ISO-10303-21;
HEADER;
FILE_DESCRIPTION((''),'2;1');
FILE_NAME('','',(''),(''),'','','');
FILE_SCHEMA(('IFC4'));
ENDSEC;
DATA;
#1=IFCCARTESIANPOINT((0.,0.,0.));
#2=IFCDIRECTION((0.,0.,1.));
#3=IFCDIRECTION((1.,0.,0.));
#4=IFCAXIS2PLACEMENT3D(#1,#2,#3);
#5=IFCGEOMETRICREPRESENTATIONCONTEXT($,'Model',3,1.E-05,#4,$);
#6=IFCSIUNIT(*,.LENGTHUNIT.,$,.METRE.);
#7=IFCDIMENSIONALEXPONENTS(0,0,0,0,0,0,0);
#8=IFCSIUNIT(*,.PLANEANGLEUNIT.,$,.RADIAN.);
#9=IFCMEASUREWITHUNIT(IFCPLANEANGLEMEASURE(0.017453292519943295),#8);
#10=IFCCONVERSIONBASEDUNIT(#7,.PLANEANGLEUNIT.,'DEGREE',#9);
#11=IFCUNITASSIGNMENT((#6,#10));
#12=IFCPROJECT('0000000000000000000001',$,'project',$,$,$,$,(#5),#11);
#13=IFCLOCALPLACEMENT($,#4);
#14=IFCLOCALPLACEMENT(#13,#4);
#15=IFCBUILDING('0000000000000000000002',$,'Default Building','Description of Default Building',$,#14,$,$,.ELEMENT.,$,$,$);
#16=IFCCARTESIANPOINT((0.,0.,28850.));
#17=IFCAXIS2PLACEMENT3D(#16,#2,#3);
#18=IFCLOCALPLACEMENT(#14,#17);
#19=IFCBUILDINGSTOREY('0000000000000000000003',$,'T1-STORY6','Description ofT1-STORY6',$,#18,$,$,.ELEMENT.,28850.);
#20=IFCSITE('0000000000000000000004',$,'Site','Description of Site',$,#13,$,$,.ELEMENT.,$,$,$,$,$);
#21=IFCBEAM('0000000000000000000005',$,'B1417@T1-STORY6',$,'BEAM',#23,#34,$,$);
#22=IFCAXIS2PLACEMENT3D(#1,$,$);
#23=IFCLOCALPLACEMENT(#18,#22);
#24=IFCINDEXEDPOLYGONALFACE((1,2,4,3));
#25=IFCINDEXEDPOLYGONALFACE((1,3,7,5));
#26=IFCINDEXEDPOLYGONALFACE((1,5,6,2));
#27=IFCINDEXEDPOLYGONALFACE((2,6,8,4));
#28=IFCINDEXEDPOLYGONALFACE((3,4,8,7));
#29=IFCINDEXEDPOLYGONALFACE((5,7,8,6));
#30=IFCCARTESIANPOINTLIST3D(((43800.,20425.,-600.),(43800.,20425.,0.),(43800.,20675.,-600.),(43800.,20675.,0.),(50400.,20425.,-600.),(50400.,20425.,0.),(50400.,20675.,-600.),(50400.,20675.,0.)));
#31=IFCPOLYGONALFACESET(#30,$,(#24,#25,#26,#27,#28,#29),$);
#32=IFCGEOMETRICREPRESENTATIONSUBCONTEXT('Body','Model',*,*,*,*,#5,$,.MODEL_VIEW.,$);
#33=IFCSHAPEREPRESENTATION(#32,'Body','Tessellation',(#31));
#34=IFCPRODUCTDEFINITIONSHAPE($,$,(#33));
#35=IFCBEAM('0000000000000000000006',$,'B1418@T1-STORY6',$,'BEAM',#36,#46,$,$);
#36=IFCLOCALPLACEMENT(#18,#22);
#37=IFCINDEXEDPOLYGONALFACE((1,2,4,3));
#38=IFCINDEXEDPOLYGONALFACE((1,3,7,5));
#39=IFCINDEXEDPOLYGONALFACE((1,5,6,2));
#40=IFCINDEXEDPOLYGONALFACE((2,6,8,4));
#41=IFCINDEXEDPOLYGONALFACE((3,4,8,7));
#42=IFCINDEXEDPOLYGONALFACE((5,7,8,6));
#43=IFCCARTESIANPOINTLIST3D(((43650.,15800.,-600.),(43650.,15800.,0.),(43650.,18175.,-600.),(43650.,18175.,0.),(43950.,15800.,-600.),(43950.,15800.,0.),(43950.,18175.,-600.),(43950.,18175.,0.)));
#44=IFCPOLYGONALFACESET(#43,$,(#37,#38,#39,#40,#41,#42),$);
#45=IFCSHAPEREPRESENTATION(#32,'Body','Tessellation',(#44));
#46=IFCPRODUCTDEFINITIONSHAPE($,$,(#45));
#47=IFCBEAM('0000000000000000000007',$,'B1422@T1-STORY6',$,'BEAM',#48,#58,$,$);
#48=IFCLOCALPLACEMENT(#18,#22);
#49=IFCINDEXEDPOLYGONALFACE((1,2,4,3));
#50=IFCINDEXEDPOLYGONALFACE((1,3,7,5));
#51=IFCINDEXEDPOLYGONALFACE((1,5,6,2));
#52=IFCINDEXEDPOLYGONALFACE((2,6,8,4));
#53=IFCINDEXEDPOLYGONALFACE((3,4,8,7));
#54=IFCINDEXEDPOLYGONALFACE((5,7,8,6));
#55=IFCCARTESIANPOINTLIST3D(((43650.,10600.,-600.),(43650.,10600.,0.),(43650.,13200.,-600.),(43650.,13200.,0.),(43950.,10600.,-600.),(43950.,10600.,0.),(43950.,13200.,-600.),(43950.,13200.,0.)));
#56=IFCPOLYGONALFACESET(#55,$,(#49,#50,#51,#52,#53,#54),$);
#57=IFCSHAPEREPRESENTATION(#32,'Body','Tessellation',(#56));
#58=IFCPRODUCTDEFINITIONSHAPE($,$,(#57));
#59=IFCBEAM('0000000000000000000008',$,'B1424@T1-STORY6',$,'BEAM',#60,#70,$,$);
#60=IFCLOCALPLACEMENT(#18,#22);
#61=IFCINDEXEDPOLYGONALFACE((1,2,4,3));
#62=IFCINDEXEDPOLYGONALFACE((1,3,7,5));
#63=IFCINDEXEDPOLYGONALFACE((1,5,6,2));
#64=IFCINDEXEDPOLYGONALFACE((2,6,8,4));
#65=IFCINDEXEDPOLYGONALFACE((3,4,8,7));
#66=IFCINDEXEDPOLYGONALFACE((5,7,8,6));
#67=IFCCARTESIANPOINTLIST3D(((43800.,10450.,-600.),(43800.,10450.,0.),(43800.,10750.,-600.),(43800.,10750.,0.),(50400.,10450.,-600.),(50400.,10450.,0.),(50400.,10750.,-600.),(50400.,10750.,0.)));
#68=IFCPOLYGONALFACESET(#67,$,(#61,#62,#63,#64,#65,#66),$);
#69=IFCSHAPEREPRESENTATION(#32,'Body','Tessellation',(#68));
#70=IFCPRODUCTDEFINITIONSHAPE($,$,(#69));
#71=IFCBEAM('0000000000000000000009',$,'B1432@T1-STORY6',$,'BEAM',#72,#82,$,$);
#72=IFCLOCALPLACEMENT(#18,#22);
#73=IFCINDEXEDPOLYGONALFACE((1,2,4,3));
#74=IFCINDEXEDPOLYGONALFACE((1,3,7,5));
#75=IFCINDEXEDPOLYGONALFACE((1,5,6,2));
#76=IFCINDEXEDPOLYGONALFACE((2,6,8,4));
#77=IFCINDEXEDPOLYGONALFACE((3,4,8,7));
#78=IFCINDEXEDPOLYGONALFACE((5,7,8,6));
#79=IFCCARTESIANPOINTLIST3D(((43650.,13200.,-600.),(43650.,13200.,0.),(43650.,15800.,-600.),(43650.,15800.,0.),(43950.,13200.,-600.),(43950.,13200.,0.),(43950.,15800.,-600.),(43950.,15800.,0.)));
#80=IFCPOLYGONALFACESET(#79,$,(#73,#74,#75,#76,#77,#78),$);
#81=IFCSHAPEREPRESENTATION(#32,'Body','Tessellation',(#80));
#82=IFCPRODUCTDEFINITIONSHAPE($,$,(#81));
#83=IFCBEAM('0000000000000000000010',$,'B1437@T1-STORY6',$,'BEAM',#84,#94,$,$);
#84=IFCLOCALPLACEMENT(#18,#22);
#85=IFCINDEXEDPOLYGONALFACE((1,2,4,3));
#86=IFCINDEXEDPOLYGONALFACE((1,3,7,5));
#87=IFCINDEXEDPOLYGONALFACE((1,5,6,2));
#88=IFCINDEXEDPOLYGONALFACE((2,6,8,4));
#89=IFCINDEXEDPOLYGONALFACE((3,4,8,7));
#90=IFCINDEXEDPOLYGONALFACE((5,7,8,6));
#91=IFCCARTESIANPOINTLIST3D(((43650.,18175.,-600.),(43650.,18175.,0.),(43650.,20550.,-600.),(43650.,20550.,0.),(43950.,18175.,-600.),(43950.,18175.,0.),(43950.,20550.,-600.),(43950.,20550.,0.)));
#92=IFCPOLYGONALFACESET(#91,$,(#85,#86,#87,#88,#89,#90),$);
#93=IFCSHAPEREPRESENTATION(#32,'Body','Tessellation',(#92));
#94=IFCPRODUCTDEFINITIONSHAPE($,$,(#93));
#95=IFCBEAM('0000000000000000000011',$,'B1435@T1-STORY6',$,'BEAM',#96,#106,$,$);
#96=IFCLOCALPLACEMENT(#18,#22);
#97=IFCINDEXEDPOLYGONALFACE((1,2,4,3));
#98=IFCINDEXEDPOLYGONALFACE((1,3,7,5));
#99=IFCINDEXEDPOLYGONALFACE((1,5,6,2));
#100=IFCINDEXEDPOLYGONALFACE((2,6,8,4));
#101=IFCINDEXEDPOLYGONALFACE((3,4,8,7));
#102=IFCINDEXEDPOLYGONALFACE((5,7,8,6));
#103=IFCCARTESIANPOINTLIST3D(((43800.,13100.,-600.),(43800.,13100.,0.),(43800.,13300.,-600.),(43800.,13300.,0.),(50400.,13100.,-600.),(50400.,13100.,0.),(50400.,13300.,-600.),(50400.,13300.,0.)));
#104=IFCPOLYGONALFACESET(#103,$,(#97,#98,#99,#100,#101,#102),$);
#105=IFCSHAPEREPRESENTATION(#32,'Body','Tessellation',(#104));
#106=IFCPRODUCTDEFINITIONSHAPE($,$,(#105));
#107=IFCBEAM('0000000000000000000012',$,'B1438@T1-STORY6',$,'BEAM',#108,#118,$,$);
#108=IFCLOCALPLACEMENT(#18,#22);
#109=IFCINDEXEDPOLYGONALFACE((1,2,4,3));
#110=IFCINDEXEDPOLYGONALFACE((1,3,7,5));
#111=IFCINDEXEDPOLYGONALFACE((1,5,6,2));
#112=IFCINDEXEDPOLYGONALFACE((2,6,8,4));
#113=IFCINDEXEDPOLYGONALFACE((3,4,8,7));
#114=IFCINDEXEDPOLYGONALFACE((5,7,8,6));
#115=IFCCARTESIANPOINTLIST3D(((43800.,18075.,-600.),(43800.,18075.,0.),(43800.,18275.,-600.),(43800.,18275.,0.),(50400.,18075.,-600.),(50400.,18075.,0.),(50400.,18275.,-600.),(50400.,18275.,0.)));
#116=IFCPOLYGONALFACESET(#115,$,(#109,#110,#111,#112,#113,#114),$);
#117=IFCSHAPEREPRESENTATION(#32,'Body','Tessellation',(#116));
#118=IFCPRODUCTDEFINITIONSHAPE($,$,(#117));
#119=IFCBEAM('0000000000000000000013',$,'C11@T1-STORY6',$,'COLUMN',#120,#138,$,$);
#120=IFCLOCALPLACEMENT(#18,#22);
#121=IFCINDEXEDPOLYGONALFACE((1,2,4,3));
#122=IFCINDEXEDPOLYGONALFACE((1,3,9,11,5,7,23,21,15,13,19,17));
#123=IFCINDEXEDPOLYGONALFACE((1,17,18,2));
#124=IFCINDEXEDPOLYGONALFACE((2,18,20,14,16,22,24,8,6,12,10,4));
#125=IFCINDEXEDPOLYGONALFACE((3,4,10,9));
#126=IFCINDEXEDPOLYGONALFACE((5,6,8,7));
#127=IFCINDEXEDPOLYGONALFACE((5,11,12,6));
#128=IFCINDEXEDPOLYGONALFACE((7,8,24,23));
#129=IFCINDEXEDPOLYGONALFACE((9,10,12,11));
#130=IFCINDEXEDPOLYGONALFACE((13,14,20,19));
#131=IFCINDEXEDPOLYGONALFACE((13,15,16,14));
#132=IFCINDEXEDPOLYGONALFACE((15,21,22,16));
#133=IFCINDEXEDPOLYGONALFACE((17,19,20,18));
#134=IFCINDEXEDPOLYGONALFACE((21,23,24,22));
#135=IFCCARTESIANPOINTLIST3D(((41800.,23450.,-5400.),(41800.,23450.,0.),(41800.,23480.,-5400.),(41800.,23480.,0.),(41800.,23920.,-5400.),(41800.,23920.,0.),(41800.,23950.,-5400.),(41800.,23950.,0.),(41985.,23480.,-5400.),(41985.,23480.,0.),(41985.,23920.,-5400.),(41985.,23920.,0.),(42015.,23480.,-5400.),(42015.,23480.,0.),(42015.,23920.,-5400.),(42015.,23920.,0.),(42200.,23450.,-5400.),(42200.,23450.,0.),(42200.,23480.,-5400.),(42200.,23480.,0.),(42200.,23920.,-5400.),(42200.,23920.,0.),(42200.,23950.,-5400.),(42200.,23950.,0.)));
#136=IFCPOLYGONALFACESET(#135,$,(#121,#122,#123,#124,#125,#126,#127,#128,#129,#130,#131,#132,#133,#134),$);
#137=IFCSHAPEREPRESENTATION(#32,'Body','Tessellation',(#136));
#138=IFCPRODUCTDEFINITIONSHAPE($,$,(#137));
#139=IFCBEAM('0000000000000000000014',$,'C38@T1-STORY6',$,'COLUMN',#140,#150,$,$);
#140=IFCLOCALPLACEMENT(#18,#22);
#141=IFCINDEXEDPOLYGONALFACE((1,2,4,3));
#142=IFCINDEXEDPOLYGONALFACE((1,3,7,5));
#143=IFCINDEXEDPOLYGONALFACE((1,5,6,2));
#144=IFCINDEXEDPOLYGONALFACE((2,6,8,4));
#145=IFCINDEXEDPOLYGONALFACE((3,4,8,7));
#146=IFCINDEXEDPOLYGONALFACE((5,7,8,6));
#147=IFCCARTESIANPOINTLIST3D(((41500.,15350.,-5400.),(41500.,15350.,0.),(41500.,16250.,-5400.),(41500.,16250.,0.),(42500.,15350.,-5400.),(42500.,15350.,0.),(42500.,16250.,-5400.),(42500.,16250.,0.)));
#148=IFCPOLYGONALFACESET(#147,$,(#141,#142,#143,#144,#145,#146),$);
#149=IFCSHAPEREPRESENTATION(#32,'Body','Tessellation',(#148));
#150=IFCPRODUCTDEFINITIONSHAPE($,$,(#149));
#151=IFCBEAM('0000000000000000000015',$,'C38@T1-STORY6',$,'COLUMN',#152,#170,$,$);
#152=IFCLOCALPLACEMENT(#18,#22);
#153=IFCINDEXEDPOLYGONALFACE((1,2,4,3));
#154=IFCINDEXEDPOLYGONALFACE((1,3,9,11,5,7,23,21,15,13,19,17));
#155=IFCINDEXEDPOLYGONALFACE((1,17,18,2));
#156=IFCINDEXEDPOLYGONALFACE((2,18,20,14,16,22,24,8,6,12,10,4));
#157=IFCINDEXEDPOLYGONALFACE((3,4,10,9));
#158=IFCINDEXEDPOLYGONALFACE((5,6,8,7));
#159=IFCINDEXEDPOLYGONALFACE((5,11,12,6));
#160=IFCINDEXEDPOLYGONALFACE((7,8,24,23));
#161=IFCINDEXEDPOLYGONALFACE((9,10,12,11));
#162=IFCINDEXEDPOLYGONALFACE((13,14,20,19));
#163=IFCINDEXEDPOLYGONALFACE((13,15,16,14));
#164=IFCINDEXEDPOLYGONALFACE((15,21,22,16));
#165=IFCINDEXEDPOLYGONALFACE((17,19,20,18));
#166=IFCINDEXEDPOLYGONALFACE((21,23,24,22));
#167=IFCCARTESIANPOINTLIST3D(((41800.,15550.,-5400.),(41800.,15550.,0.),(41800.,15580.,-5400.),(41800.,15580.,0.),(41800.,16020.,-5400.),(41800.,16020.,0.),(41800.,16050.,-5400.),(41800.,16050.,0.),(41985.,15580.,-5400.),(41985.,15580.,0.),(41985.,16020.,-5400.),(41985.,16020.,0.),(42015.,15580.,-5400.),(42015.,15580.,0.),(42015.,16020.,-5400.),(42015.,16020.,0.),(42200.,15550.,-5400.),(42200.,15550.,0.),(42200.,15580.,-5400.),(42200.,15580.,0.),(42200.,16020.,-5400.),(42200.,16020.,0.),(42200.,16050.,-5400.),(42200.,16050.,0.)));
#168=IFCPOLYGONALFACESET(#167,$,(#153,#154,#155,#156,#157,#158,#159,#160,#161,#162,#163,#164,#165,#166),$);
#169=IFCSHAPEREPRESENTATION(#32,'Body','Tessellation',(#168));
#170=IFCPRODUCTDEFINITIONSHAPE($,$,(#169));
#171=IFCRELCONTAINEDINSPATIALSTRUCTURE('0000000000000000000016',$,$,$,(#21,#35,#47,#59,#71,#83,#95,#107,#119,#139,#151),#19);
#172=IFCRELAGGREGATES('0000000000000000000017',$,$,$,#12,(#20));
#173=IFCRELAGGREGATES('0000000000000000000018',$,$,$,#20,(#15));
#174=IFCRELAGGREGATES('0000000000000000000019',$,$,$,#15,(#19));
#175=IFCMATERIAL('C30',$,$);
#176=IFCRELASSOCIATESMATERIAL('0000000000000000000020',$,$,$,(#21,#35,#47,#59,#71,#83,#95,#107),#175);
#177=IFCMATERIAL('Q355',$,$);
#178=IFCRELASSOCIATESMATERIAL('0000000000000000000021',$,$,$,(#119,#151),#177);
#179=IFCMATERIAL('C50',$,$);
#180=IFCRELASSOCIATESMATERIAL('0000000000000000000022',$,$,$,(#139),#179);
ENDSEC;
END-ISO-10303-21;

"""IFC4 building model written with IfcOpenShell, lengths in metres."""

from ifc_helpers import new_model, entity, si_unit, converted_unit, frame, origin_with_axes, place, context, subcontext, project, spatial, rectangle, i_section, extrude, material, element, save


model = new_model("IFC4")

# Units and contexts
model_context = context("Model", 3, precision=1e-05, world=origin_with_axes())
body_context = subcontext(model_context, "Body", "Model", "MODEL_VIEW")
ifc_project = project(units=[si_unit("LENGTHUNIT", "METRE"), converted_unit("PLANEANGLEUNIT", "DEGREE", entity("IfcPlaneAngleMeasure", 0.017453292519943295), si_unit("PLANEANGLEUNIT", "RADIAN"), dimensions=[0, 0, 0, 0, 0, 0, 0])], contexts=[model_context])

# Site, building, storey
site_placement = place(None, origin_with_axes())
site = spatial("IfcSite", under=ifc_project, at=site_placement, Name="Site", Description="Description of Site", CompositionType="ELEMENT")
building_placement = place(site_placement, origin_with_axes())
building = spatial("IfcBuilding", under=site, at=building_placement, Name="Default Building", Description="Description of Default Building", CompositionType="ELEMENT")
storey_placement = place(building_placement, frame((0.0, 0.0, 28850.0), z_axis=(0.0, 0.0, 1.0), x_axis=(1.0, 0.0, 0.0)))
storey = spatial("IfcBuildingStorey", under=building, at=storey_placement, Name="T1-STORY6", Description="Description ofT1-STORY6", CompositionType="ELEMENT", Elevation=28850.0)

# Beams
ifc_material_1 = material(Name="C30")
ifc_material_2 = material(Name="C50")
beam_1_placement = place(storey_placement, frame((43800.0, 20550.0, -300.0), z_axis=(1.0, 0.0, 0.0), x_axis=(0.0, 1.0, 0.0)))
element("IfcBeam", 1, at=beam_1_placement, inside=storey, material=ifc_material_1, Name="B1417@T1-STORY6", ObjectType="BEAM", context=body_context, shape_type="SweptSolid", body=[
    extrude(rectangle(XDim=250.0, YDim=600.0), origin_with_axes(), (0.0, 0.0, 1.0), 6600.0),
])
beam_2_placement = place(storey_placement, frame((43800.0, 15800.0, -300.0), z_axis=(0.0, 1.0, 0.0), x_axis=(-1.0, 0.0, 0.0)))
element("IfcBeam", 2, at=beam_2_placement, inside=storey, material=ifc_material_1, Name="B1418@T1-STORY6", ObjectType="BEAM", context=body_context, shape_type="SweptSolid", body=[
    extrude(rectangle(XDim=300.0, YDim=600.0), origin_with_axes(), (0.0, 0.0, 1.0), 2375.0),
])
beam_3_placement = place(storey_placement, frame((43800.0, 10600.0, -300.0), z_axis=(0.0, 1.0, 0.0), x_axis=(-1.0, 0.0, 0.0)))
element("IfcBeam", 3, at=beam_3_placement, inside=storey, material=ifc_material_1, Name="B1422@T1-STORY6", ObjectType="BEAM", context=body_context, shape_type="SweptSolid", body=[
    extrude(rectangle(XDim=300.0, YDim=600.0), origin_with_axes(), (0.0, 0.0, 1.0), 2600.0),
])
beam_4_placement = place(storey_placement, frame((43800.0, 10600.0, -300.0), z_axis=(1.0, 0.0, 0.0), x_axis=(0.0, 1.0, 0.0)))
element("IfcBeam", 4, at=beam_4_placement, inside=storey, material=ifc_material_1, Name="B1424@T1-STORY6", ObjectType="BEAM", context=body_context, shape_type="SweptSolid", body=[
    extrude(rectangle(XDim=300.0, YDim=600.0), origin_with_axes(), (0.0, 0.0, 1.0), 6600.0),
])
beam_5_placement = place(storey_placement, frame((43800.0, 13200.0, -300.0), z_axis=(0.0, 1.0, 0.0), x_axis=(-1.0, 0.0, 0.0)))
element("IfcBeam", 5, at=beam_5_placement, inside=storey, material=ifc_material_1, Name="B1432@T1-STORY6", ObjectType="BEAM", context=body_context, shape_type="SweptSolid", body=[
    extrude(rectangle(XDim=300.0, YDim=600.0), origin_with_axes(), (0.0, 0.0, 1.0), 2600.0),
])
beam_6_placement = place(storey_placement, frame((43800.0, 18175.0, -300.0), z_axis=(0.0, 1.0, 0.0), x_axis=(-1.0, 0.0, 0.0)))
element("IfcBeam", 6, at=beam_6_placement, inside=storey, material=ifc_material_1, Name="B1437@T1-STORY6", ObjectType="BEAM", context=body_context, shape_type="SweptSolid", body=[
    extrude(rectangle(XDim=300.0, YDim=600.0), origin_with_axes(), (0.0, 0.0, 1.0), 2375.0),
])
for number, where, z_axis, x_axis, name in (
    (7, (43800.0, 13200.0, -300.0), (1.0, 0.0, 0.0), (0.0, 1.0, 0.0), "B1435@T1-STORY6"),
    (8, (43800.0, 18175.0, -300.0), (1.0, 0.0, 0.0), (0.0, 1.0, 0.0), "B1438@T1-STORY6"),
):
    element("IfcBeam", number, at=place(storey_placement, frame(where, z_axis=z_axis, x_axis=x_axis)), inside=storey, material=ifc_material_1, Name=name, ObjectType="BEAM", context=body_context, shape_type="SweptSolid", body=[
        extrude(rectangle(XDim=200.0, YDim=600.0), origin_with_axes(), (0.0, 0.0, 1.0), 6600.0),
    ])
ifc_material_3 = material(Name="Q355")
beam_7_placement = place(storey_placement, frame((42000.0, 23700.0, -5400.0), z_axis=(0.0, 0.0, 1.0), x_axis=(-1.0, 0.0, 0.0)))
element("IfcBeam", 9, at=beam_7_placement, inside=storey, material=ifc_material_3, Name="C11@T1-STORY6", ObjectType="COLUMN", context=body_context, shape_type="SweptSolid", body=[
    extrude(i_section(OverallWidth=400.0, OverallDepth=500.0, WebThickness=30.0, FlangeThickness=30.0, FilletRadius=0.0), origin_with_axes(), (0.0, 0.0, 1.0), 5400.0),
])
beam_8_placement = place(storey_placement, frame((42000.0, 15800.0, -5400.0), z_axis=(0.0, 0.0, 1.0), x_axis=(-1.0, 0.0, 0.0)))
element("IfcBeam", 10, at=beam_8_placement, inside=storey, material=ifc_material_2, Name="C38@T1-STORY6", ObjectType="COLUMN", context=body_context, shape_type="SweptSolid", body=[
    extrude(rectangle(XDim=1000.0, YDim=900.0), origin_with_axes(), (0.0, 0.0, 1.0), 5400.0),
])
beam_9_placement = place(storey_placement, frame((42000.0, 15800.0, -5400.0), z_axis=(0.0, 0.0, 1.0), x_axis=(-1.0, 0.0, 0.0)))
element("IfcBeam", 11, at=beam_9_placement, inside=storey, material=ifc_material_3, Name="C38@T1-STORY6", ObjectType="COLUMN", context=body_context, shape_type="SweptSolid", body=[
    extrude(i_section(OverallWidth=400.0, OverallDepth=500.0, WebThickness=30.0, FlangeThickness=30.0, FilletRadius=0.0), origin_with_axes(), (0.0, 0.0, 1.0), 5400.0),
])

save(model, "model.ifc")
